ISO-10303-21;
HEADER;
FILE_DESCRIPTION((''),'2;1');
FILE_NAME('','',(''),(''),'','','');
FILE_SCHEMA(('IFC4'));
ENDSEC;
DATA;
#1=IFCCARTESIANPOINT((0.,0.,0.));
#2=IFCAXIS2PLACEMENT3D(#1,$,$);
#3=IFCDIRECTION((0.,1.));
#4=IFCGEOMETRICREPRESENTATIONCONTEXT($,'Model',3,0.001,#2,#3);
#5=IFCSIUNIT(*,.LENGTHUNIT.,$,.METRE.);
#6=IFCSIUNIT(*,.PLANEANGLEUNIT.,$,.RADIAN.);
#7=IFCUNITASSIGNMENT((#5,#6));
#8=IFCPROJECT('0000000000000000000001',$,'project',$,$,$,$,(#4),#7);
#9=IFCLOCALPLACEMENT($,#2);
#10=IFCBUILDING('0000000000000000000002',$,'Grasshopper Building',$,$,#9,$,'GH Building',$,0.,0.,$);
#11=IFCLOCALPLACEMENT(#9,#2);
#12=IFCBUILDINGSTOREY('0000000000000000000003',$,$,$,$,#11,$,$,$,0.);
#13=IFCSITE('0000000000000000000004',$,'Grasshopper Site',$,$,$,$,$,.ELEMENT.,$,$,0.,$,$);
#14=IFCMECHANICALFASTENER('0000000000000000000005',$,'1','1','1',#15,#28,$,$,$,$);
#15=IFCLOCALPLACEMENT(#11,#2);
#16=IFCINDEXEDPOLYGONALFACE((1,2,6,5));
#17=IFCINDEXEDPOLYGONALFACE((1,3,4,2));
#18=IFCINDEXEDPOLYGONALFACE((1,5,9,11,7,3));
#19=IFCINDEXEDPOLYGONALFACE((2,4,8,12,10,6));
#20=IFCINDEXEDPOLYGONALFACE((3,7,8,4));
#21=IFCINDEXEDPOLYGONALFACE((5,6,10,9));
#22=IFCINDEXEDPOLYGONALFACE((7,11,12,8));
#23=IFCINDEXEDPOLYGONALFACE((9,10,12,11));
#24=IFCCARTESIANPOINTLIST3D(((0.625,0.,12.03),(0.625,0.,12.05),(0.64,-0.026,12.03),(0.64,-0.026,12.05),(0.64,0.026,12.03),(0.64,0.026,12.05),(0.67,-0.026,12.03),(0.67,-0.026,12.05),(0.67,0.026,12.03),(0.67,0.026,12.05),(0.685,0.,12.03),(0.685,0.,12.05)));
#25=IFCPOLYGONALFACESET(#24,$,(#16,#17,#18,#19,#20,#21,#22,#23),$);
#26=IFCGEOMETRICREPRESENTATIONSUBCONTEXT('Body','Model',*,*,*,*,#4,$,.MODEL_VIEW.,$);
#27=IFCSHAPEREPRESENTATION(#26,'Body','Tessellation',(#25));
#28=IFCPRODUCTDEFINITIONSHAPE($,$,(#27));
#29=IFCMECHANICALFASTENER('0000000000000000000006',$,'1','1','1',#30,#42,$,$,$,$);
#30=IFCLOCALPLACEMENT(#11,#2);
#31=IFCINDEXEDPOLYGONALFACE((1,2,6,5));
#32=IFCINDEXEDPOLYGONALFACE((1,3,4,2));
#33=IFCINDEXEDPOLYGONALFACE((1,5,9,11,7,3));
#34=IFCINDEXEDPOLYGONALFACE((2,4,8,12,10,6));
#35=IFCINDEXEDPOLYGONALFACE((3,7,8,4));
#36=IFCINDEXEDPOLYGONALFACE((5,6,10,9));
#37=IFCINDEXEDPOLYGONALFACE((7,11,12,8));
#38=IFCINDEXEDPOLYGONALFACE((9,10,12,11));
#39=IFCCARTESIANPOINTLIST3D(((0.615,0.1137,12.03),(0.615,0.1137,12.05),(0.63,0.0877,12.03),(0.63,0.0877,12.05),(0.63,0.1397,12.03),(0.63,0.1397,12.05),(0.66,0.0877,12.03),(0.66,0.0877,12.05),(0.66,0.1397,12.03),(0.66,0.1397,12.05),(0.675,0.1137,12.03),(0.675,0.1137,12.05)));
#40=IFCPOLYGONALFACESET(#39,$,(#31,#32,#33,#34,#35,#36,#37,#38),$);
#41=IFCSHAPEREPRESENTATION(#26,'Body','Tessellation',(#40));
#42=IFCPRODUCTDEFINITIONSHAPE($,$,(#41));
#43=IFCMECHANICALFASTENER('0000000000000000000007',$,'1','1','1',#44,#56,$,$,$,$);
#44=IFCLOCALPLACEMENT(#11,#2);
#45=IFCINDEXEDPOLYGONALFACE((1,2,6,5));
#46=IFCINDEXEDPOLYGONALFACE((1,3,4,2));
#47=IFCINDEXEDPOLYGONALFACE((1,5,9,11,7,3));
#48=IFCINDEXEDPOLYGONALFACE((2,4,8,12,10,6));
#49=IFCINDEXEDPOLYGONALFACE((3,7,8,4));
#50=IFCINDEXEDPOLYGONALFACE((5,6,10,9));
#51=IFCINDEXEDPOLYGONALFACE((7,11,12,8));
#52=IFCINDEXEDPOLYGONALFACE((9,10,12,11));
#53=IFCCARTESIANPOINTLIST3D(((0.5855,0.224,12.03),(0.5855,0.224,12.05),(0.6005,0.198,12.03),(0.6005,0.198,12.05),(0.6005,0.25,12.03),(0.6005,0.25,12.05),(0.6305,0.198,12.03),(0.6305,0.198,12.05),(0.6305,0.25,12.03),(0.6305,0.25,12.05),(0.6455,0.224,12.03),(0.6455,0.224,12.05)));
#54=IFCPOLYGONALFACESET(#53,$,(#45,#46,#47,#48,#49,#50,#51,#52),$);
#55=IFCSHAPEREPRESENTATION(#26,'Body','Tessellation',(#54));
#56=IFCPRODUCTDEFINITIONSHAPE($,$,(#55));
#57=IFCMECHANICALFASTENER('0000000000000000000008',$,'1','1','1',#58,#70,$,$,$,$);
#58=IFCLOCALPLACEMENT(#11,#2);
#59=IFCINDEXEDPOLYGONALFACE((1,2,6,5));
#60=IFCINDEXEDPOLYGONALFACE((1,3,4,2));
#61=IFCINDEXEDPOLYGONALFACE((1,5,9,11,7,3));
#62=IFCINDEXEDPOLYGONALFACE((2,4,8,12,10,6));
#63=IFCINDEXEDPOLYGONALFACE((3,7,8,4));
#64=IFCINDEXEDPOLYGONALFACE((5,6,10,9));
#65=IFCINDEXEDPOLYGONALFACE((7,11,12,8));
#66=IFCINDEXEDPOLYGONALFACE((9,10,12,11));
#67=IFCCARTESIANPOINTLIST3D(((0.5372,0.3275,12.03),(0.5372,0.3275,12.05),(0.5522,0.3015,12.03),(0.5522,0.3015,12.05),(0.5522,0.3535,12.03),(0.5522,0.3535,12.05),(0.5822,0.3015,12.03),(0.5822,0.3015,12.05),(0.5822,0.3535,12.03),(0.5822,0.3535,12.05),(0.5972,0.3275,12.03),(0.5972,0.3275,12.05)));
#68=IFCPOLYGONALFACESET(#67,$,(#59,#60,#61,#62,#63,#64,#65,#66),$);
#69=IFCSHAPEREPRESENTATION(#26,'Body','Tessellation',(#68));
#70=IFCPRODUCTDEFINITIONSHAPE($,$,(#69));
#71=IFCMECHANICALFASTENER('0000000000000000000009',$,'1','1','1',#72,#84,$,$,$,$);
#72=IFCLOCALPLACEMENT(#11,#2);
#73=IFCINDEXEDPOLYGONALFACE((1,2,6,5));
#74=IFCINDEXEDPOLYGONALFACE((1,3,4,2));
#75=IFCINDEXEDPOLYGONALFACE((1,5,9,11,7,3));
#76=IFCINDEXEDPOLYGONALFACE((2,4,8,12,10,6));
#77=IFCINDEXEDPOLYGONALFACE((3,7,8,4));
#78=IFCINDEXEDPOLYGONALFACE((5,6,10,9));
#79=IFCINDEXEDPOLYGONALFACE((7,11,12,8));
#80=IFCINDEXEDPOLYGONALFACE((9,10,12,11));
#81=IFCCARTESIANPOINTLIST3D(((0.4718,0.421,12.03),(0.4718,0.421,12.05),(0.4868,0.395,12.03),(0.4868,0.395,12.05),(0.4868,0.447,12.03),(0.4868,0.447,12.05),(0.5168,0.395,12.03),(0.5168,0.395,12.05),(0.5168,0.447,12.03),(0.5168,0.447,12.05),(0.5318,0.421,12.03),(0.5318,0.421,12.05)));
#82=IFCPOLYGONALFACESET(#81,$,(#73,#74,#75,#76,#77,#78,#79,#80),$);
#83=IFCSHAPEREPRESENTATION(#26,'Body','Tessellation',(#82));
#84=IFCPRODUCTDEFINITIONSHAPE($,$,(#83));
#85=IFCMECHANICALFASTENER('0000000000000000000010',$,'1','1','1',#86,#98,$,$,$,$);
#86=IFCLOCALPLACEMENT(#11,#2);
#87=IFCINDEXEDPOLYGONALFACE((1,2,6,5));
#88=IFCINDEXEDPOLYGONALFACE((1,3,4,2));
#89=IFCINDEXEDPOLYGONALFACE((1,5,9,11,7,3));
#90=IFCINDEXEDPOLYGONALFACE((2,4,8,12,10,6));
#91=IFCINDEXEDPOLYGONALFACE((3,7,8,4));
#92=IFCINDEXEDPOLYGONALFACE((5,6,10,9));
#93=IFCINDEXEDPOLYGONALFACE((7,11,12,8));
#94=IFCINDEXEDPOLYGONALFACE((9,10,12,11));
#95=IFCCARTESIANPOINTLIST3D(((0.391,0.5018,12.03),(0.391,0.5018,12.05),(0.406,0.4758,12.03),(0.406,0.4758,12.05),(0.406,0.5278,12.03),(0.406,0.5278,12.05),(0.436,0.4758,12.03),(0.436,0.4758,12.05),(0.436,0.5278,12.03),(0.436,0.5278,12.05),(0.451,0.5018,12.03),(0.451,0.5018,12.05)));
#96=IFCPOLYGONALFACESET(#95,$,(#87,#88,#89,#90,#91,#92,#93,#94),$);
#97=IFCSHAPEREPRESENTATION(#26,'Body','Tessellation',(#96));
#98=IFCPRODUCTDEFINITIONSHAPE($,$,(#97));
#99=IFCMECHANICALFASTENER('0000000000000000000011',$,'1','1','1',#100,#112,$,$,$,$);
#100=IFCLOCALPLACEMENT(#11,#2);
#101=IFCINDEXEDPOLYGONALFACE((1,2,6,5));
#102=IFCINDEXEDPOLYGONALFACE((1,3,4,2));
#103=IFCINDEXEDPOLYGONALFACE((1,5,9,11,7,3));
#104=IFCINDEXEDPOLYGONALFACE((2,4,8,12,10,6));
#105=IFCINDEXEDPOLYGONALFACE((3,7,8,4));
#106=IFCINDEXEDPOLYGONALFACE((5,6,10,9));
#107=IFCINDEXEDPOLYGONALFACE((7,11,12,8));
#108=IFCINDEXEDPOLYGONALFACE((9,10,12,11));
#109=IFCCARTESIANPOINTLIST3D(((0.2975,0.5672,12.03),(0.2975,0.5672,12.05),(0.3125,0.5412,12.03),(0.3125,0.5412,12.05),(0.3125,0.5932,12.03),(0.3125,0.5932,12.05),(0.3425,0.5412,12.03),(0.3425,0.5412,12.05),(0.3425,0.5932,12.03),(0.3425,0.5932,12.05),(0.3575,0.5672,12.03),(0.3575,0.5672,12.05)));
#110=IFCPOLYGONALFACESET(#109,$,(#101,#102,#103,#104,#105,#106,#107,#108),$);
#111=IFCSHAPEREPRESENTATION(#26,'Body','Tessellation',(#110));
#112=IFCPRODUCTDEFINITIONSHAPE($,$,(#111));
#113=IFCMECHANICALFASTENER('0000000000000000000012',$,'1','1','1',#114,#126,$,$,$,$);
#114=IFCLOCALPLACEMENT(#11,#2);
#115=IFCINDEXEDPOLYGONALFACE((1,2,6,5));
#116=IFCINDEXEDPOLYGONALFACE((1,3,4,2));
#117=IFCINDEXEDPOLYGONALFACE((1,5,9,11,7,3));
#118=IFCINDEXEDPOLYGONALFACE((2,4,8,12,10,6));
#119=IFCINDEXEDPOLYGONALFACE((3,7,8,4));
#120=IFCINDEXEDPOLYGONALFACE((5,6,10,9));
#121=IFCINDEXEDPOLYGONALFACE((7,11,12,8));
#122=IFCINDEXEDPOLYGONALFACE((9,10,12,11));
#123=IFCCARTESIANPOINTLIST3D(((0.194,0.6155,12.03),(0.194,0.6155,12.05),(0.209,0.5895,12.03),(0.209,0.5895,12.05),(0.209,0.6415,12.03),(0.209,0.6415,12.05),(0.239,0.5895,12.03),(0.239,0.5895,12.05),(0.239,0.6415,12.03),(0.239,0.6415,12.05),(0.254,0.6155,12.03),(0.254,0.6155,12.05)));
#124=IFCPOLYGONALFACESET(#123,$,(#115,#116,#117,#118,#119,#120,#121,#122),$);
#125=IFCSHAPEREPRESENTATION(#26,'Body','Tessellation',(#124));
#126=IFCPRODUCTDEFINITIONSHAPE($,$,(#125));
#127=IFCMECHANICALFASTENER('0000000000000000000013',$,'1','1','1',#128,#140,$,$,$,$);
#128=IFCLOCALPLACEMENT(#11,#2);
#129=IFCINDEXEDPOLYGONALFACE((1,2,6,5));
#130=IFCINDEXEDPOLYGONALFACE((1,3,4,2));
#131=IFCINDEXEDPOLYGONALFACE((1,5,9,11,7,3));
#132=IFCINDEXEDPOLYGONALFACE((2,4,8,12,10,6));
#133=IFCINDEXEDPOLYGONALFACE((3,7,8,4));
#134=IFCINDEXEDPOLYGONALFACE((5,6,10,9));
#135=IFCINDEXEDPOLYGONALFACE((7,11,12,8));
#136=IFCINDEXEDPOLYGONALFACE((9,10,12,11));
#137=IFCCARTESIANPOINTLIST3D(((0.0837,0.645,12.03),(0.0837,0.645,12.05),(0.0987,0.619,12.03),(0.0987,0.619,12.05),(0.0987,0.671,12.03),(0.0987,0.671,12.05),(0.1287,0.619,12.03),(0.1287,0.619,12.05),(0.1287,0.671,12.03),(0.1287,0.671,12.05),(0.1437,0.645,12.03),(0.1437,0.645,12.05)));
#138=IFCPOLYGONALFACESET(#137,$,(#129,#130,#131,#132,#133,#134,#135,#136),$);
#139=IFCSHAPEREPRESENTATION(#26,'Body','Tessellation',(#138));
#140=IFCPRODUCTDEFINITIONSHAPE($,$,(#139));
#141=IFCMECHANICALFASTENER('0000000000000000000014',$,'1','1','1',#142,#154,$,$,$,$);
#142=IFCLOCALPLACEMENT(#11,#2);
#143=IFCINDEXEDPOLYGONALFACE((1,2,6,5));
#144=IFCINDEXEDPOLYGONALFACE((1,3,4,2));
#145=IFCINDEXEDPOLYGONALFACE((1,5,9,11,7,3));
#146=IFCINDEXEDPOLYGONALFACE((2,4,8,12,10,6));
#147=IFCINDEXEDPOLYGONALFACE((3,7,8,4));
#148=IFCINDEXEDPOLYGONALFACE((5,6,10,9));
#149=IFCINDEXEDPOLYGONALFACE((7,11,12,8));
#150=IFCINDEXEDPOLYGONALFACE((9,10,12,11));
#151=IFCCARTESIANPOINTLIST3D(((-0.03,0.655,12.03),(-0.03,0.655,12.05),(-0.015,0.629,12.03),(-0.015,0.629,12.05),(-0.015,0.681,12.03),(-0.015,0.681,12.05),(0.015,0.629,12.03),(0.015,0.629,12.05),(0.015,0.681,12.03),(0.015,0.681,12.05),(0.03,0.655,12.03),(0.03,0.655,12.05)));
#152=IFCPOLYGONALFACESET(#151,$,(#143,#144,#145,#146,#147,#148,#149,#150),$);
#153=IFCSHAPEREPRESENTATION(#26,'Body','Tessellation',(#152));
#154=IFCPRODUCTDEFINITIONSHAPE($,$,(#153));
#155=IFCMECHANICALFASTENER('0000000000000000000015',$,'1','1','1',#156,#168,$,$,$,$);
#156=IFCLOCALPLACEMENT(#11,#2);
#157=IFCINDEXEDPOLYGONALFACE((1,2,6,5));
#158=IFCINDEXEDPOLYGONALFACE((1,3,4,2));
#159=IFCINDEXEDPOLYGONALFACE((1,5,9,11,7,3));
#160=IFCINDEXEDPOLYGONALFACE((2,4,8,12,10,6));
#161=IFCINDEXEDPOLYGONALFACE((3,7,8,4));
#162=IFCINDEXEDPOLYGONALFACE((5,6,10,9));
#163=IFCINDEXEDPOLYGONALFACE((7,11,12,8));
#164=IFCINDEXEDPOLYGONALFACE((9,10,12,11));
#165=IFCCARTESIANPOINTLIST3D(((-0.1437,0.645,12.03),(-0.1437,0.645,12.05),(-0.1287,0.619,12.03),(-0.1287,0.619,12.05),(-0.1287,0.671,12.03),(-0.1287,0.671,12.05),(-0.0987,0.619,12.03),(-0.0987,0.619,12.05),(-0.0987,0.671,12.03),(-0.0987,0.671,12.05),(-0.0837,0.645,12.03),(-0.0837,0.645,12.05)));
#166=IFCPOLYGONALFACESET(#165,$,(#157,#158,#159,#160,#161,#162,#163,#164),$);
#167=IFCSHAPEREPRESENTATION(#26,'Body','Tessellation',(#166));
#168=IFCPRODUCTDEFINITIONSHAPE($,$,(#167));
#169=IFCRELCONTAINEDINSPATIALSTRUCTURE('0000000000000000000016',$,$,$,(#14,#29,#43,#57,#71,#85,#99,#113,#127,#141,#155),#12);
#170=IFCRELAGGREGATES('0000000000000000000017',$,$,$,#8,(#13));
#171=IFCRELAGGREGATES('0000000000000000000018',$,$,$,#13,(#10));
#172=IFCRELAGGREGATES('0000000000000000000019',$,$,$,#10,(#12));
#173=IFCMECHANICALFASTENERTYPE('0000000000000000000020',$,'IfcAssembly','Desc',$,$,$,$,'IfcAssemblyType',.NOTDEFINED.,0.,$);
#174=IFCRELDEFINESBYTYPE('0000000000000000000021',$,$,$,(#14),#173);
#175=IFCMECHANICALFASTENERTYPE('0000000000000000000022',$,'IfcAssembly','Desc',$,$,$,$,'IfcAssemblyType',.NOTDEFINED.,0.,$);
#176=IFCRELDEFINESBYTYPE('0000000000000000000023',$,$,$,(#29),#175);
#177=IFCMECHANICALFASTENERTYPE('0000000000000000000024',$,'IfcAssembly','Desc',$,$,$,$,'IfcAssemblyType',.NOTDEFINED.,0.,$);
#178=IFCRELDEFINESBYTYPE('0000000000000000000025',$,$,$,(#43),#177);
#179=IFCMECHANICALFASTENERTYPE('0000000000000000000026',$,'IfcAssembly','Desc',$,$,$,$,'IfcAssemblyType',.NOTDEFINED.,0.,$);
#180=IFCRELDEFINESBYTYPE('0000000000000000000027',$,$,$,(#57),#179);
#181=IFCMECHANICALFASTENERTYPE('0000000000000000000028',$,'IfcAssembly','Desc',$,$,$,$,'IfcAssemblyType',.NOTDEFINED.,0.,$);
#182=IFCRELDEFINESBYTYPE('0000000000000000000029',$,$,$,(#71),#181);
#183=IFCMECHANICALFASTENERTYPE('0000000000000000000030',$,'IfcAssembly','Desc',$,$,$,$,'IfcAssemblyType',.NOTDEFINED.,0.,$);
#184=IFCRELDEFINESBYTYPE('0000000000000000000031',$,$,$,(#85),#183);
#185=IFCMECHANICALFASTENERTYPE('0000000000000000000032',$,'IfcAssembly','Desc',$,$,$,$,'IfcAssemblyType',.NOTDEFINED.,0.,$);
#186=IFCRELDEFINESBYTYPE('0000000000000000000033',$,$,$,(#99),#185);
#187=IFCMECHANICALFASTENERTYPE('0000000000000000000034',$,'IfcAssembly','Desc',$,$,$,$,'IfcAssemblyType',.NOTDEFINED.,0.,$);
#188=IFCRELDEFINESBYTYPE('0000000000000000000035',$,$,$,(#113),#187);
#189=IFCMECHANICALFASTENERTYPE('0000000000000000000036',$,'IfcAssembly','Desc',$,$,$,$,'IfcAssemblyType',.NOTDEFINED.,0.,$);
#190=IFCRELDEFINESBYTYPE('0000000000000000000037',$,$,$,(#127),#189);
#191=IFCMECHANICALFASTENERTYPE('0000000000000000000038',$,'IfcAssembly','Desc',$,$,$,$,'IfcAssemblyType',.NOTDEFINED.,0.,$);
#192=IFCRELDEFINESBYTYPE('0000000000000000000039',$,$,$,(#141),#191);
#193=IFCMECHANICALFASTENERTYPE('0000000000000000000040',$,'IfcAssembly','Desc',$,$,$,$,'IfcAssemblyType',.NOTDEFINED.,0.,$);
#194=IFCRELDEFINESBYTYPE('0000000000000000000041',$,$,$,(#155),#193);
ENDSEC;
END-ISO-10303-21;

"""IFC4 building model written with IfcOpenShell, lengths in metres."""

from ifc_helpers import new_model, si_unit, direction, frame, origin, place, context, subcontext, project, spatial, indexed_curve, outline, extrude, source, transform, mapped, type_object, type_shapes, element, save


model = new_model("IFC4")

# Units and contexts
model_context = context("Model", 3, precision=0.001, world=origin(), true_north=direction((0.0, 1.0)))
body_context = subcontext(model_context, "Body", "Model", "MODEL_VIEW")
ifc_project = project(units=[si_unit("LENGTHUNIT", "METRE"), si_unit("PLANEANGLEUNIT", "RADIAN")], contexts=[model_context])

# Site, building, storey
site = spatial("IfcSite", under=ifc_project, Name="Grasshopper Site", CompositionType="ELEMENT", RefElevation=0.0)
building_placement = place(None, origin())
building = spatial("IfcBuilding", under=site, at=building_placement, Name="Grasshopper Building", LongName="GH Building", ElevationOfRefHeight=0.0, ElevationOfTerrain=0.0)
storey_placement = place(building_placement, origin())
storey = spatial("IfcBuildingStorey", under=building, at=storey_placement, Elevation=0.0)

# Mechanical fasteners
mechanical_fastener_type_1 = type_object("IfcMechanicalFastenerType", Name="IfcAssembly", Description="Desc", ElementType="IfcAssemblyType", NominalDiameter=0.0)
shared_shape_1 = source(origin(), body_context, "Body", "SweptSolid", [
    extrude(outline(indexed_curve([(0.03, 0.0), (0.015, 0.026), (-0.015, 0.026), (-0.03, 0.0), (-0.015, -0.026), (0.015, -0.026), (0.03, 0.0)])), frame((0.655, 0.0, 12.03)), (0.0, 0.0, 1.0), 0.02),
])
type_shapes(mechanical_fastener_type_1, [shared_shape_1])
mechanical_fastener_1_placement = place(storey_placement, origin())
element("IfcMechanicalFastener", 1, at=mechanical_fastener_1_placement, inside=storey, type_object=mechanical_fastener_type_1, Name="1", Description="1", ObjectType="1", context=body_context, shape_type="MappedRepresentation", body=[
    mapped(shared_shape_1, transform((0.0, 0.0, 0.0), scale=1.0)),
])
mechanical_fastener_type_2 = type_object("IfcMechanicalFastenerType", Name="IfcAssembly", Description="Desc", ElementType="IfcAssemblyType", NominalDiameter=0.0)
shared_shape_2 = source(origin(), body_context, "Body", "SweptSolid", [
    extrude(outline(indexed_curve([(0.03, 0.0), (0.015, 0.026), (-0.015, 0.026), (-0.03, 0.0), (-0.015, -0.026), (0.015, -0.026), (0.03, 0.0)])), frame((0.645, 0.1137, 12.03)), (0.0, 0.0, 1.0), 0.02),
])
type_shapes(mechanical_fastener_type_2, [shared_shape_2])
mechanical_fastener_2_placement = place(storey_placement, origin())
element("IfcMechanicalFastener", 2, at=mechanical_fastener_2_placement, inside=storey, type_object=mechanical_fastener_type_2, Name="1", Description="1", ObjectType="1", context=body_context, shape_type="MappedRepresentation", body=[
    mapped(shared_shape_2, transform((0.0, 0.0, 0.0), scale=1.0)),
])
mechanical_fastener_type_3 = type_object("IfcMechanicalFastenerType", Name="IfcAssembly", Description="Desc", ElementType="IfcAssemblyType", NominalDiameter=0.0)
shared_shape_3 = source(origin(), body_context, "Body", "SweptSolid", [
    extrude(outline(indexed_curve([(0.03, 0.0), (0.015, 0.026), (-0.015, 0.026), (-0.03, 0.0), (-0.015, -0.026), (0.015, -0.026), (0.03, 0.0)])), frame((0.6155, 0.224, 12.03)), (0.0, 0.0, 1.0), 0.02),
])
type_shapes(mechanical_fastener_type_3, [shared_shape_3])
mechanical_fastener_3_placement = place(storey_placement, origin())
element("IfcMechanicalFastener", 3, at=mechanical_fastener_3_placement, inside=storey, type_object=mechanical_fastener_type_3, Name="1", Description="1", ObjectType="1", context=body_context, shape_type="MappedRepresentation", body=[
    mapped(shared_shape_3, transform((0.0, 0.0, 0.0), scale=1.0)),
])
mechanical_fastener_type_4 = type_object("IfcMechanicalFastenerType", Name="IfcAssembly", Description="Desc", ElementType="IfcAssemblyType", NominalDiameter=0.0)
shared_shape_4 = source(origin(), body_context, "Body", "SweptSolid", [
    extrude(outline(indexed_curve([(0.03, 0.0), (0.015, 0.026), (-0.015, 0.026), (-0.03, 0.0), (-0.015, -0.026), (0.015, -0.026), (0.03, 0.0)])), frame((0.5672, 0.3275, 12.03)), (0.0, 0.0, 1.0), 0.02),
])
type_shapes(mechanical_fastener_type_4, [shared_shape_4])
mechanical_fastener_4_placement = place(storey_placement, origin())
element("IfcMechanicalFastener", 4, at=mechanical_fastener_4_placement, inside=storey, type_object=mechanical_fastener_type_4, Name="1", Description="1", ObjectType="1", context=body_context, shape_type="MappedRepresentation", body=[
    mapped(shared_shape_4, transform((0.0, 0.0, 0.0), scale=1.0)),
])
mechanical_fastener_type_5 = type_object("IfcMechanicalFastenerType", Name="IfcAssembly", Description="Desc", ElementType="IfcAssemblyType", NominalDiameter=0.0)
shared_shape_5 = source(origin(), body_context, "Body", "SweptSolid", [
    extrude(outline(indexed_curve([(0.03, 0.0), (0.015, 0.026), (-0.015, 0.026), (-0.03, 0.0), (-0.015, -0.026), (0.015, -0.026), (0.03, 0.0)])), frame((0.5018, 0.421, 12.03)), (0.0, 0.0, 1.0), 0.02),
])
type_shapes(mechanical_fastener_type_5, [shared_shape_5])
mechanical_fastener_5_placement = place(storey_placement, origin())
element("IfcMechanicalFastener", 5, at=mechanical_fastener_5_placement, inside=storey, type_object=mechanical_fastener_type_5, Name="1", Description="1", ObjectType="1", context=body_context, shape_type="MappedRepresentation", body=[
    mapped(shared_shape_5, transform((0.0, 0.0, 0.0), scale=1.0)),
])
mechanical_fastener_type_6 = type_object("IfcMechanicalFastenerType", Name="IfcAssembly", Description="Desc", ElementType="IfcAssemblyType", NominalDiameter=0.0)
shared_shape_6 = source(origin(), body_context, "Body", "SweptSolid", [
    extrude(outline(indexed_curve([(0.03, 0.0), (0.015, 0.026), (-0.015, 0.026), (-0.03, 0.0), (-0.015, -0.026), (0.015, -0.026), (0.03, 0.0)])), frame((0.421, 0.5018, 12.03)), (0.0, 0.0, 1.0), 0.02),
])
type_shapes(mechanical_fastener_type_6, [shared_shape_6])
mechanical_fastener_6_placement = place(storey_placement, origin())
element("IfcMechanicalFastener", 6, at=mechanical_fastener_6_placement, inside=storey, type_object=mechanical_fastener_type_6, Name="1", Description="1", ObjectType="1", context=body_context, shape_type="MappedRepresentation", body=[
    mapped(shared_shape_6, transform((0.0, 0.0, 0.0), scale=1.0)),
])
mechanical_fastener_type_7 = type_object("IfcMechanicalFastenerType", Name="IfcAssembly", Description="Desc", ElementType="IfcAssemblyType", NominalDiameter=0.0)
shared_shape_7 = source(origin(), body_context, "Body", "SweptSolid", [
    extrude(outline(indexed_curve([(0.03, 0.0), (0.015, 0.026), (-0.015, 0.026), (-0.03, 0.0), (-0.015, -0.026), (0.015, -0.026), (0.03, 0.0)])), frame((0.3275, 0.5672, 12.03)), (0.0, 0.0, 1.0), 0.02),
])
type_shapes(mechanical_fastener_type_7, [shared_shape_7])
mechanical_fastener_7_placement = place(storey_placement, origin())
element("IfcMechanicalFastener", 7, at=mechanical_fastener_7_placement, inside=storey, type_object=mechanical_fastener_type_7, Name="1", Description="1", ObjectType="1", context=body_context, shape_type="MappedRepresentation", body=[
    mapped(shared_shape_7, transform((0.0, 0.0, 0.0), scale=1.0)),
])
mechanical_fastener_type_8 = type_object("IfcMechanicalFastenerType", Name="IfcAssembly", Description="Desc", ElementType="IfcAssemblyType", NominalDiameter=0.0)
shared_shape_8 = source(origin(), body_context, "Body", "SweptSolid", [
    extrude(outline(indexed_curve([(0.03, 0.0), (0.015, 0.026), (-0.015, 0.026), (-0.03, 0.0), (-0.015, -0.026), (0.015, -0.026), (0.03, 0.0)])), frame((0.224, 0.6155, 12.03)), (0.0, 0.0, 1.0), 0.02),
])
type_shapes(mechanical_fastener_type_8, [shared_shape_8])
mechanical_fastener_8_placement = place(storey_placement, origin())
element("IfcMechanicalFastener", 8, at=mechanical_fastener_8_placement, inside=storey, type_object=mechanical_fastener_type_8, Name="1", Description="1", ObjectType="1", context=body_context, shape_type="MappedRepresentation", body=[
    mapped(shared_shape_8, transform((0.0, 0.0, 0.0), scale=1.0)),
])
mechanical_fastener_type_9 = type_object("IfcMechanicalFastenerType", Name="IfcAssembly", Description="Desc", ElementType="IfcAssemblyType", NominalDiameter=0.0)
shared_shape_9 = source(origin(), body_context, "Body", "SweptSolid", [
    extrude(outline(indexed_curve([(0.03, 0.0), (0.015, 0.026), (-0.015, 0.026), (-0.03, 0.0), (-0.015, -0.026), (0.015, -0.026), (0.03, 0.0)])), frame((0.1137, 0.645, 12.03)), (0.0, 0.0, 1.0), 0.02),
])
type_shapes(mechanical_fastener_type_9, [shared_shape_9])
mechanical_fastener_9_placement = place(storey_placement, origin())
element("IfcMechanicalFastener", 9, at=mechanical_fastener_9_placement, inside=storey, type_object=mechanical_fastener_type_9, Name="1", Description="1", ObjectType="1", context=body_context, shape_type="MappedRepresentation", body=[
    mapped(shared_shape_9, transform((0.0, 0.0, 0.0), scale=1.0)),
])
mechanical_fastener_type_10 = type_object("IfcMechanicalFastenerType", Name="IfcAssembly", Description="Desc", ElementType="IfcAssemblyType", NominalDiameter=0.0)
shared_shape_10 = source(origin(), body_context, "Body", "SweptSolid", [
    extrude(outline(indexed_curve([(0.03, 0.0), (0.015, 0.026), (-0.015, 0.026), (-0.03, 0.0), (-0.015, -0.026), (0.015, -0.026), (0.03, 0.0)])), frame((0.0, 0.655, 12.03)), (0.0, 0.0, 1.0), 0.02),
])
type_shapes(mechanical_fastener_type_10, [shared_shape_10])
mechanical_fastener_10_placement = place(storey_placement, origin())
element("IfcMechanicalFastener", 10, at=mechanical_fastener_10_placement, inside=storey, type_object=mechanical_fastener_type_10, Name="1", Description="1", ObjectType="1", context=body_context, shape_type="MappedRepresentation", body=[
    mapped(shared_shape_10, transform((0.0, 0.0, 0.0), scale=1.0)),
])
mechanical_fastener_type_11 = type_object("IfcMechanicalFastenerType", Name="IfcAssembly", Description="Desc", ElementType="IfcAssemblyType", NominalDiameter=0.0)
shared_shape_11 = source(origin(), body_context, "Body", "SweptSolid", [
    extrude(outline(indexed_curve([(0.03, 0.0), (0.015, 0.026), (-0.015, 0.026), (-0.03, 0.0), (-0.015, -0.026), (0.015, -0.026), (0.03, 0.0)])), frame((-0.1137, 0.645, 12.03)), (0.0, 0.0, 1.0), 0.02),
])
type_shapes(mechanical_fastener_type_11, [shared_shape_11])
mechanical_fastener_11_placement = place(storey_placement, origin())
element("IfcMechanicalFastener", 11, at=mechanical_fastener_11_placement, inside=storey, type_object=mechanical_fastener_type_11, Name="1", Description="1", ObjectType="1", context=body_context, shape_type="MappedRepresentation", body=[
    mapped(shared_shape_11, transform((0.0, 0.0, 0.0), scale=1.0)),
])

save(model, "model.ifc")
